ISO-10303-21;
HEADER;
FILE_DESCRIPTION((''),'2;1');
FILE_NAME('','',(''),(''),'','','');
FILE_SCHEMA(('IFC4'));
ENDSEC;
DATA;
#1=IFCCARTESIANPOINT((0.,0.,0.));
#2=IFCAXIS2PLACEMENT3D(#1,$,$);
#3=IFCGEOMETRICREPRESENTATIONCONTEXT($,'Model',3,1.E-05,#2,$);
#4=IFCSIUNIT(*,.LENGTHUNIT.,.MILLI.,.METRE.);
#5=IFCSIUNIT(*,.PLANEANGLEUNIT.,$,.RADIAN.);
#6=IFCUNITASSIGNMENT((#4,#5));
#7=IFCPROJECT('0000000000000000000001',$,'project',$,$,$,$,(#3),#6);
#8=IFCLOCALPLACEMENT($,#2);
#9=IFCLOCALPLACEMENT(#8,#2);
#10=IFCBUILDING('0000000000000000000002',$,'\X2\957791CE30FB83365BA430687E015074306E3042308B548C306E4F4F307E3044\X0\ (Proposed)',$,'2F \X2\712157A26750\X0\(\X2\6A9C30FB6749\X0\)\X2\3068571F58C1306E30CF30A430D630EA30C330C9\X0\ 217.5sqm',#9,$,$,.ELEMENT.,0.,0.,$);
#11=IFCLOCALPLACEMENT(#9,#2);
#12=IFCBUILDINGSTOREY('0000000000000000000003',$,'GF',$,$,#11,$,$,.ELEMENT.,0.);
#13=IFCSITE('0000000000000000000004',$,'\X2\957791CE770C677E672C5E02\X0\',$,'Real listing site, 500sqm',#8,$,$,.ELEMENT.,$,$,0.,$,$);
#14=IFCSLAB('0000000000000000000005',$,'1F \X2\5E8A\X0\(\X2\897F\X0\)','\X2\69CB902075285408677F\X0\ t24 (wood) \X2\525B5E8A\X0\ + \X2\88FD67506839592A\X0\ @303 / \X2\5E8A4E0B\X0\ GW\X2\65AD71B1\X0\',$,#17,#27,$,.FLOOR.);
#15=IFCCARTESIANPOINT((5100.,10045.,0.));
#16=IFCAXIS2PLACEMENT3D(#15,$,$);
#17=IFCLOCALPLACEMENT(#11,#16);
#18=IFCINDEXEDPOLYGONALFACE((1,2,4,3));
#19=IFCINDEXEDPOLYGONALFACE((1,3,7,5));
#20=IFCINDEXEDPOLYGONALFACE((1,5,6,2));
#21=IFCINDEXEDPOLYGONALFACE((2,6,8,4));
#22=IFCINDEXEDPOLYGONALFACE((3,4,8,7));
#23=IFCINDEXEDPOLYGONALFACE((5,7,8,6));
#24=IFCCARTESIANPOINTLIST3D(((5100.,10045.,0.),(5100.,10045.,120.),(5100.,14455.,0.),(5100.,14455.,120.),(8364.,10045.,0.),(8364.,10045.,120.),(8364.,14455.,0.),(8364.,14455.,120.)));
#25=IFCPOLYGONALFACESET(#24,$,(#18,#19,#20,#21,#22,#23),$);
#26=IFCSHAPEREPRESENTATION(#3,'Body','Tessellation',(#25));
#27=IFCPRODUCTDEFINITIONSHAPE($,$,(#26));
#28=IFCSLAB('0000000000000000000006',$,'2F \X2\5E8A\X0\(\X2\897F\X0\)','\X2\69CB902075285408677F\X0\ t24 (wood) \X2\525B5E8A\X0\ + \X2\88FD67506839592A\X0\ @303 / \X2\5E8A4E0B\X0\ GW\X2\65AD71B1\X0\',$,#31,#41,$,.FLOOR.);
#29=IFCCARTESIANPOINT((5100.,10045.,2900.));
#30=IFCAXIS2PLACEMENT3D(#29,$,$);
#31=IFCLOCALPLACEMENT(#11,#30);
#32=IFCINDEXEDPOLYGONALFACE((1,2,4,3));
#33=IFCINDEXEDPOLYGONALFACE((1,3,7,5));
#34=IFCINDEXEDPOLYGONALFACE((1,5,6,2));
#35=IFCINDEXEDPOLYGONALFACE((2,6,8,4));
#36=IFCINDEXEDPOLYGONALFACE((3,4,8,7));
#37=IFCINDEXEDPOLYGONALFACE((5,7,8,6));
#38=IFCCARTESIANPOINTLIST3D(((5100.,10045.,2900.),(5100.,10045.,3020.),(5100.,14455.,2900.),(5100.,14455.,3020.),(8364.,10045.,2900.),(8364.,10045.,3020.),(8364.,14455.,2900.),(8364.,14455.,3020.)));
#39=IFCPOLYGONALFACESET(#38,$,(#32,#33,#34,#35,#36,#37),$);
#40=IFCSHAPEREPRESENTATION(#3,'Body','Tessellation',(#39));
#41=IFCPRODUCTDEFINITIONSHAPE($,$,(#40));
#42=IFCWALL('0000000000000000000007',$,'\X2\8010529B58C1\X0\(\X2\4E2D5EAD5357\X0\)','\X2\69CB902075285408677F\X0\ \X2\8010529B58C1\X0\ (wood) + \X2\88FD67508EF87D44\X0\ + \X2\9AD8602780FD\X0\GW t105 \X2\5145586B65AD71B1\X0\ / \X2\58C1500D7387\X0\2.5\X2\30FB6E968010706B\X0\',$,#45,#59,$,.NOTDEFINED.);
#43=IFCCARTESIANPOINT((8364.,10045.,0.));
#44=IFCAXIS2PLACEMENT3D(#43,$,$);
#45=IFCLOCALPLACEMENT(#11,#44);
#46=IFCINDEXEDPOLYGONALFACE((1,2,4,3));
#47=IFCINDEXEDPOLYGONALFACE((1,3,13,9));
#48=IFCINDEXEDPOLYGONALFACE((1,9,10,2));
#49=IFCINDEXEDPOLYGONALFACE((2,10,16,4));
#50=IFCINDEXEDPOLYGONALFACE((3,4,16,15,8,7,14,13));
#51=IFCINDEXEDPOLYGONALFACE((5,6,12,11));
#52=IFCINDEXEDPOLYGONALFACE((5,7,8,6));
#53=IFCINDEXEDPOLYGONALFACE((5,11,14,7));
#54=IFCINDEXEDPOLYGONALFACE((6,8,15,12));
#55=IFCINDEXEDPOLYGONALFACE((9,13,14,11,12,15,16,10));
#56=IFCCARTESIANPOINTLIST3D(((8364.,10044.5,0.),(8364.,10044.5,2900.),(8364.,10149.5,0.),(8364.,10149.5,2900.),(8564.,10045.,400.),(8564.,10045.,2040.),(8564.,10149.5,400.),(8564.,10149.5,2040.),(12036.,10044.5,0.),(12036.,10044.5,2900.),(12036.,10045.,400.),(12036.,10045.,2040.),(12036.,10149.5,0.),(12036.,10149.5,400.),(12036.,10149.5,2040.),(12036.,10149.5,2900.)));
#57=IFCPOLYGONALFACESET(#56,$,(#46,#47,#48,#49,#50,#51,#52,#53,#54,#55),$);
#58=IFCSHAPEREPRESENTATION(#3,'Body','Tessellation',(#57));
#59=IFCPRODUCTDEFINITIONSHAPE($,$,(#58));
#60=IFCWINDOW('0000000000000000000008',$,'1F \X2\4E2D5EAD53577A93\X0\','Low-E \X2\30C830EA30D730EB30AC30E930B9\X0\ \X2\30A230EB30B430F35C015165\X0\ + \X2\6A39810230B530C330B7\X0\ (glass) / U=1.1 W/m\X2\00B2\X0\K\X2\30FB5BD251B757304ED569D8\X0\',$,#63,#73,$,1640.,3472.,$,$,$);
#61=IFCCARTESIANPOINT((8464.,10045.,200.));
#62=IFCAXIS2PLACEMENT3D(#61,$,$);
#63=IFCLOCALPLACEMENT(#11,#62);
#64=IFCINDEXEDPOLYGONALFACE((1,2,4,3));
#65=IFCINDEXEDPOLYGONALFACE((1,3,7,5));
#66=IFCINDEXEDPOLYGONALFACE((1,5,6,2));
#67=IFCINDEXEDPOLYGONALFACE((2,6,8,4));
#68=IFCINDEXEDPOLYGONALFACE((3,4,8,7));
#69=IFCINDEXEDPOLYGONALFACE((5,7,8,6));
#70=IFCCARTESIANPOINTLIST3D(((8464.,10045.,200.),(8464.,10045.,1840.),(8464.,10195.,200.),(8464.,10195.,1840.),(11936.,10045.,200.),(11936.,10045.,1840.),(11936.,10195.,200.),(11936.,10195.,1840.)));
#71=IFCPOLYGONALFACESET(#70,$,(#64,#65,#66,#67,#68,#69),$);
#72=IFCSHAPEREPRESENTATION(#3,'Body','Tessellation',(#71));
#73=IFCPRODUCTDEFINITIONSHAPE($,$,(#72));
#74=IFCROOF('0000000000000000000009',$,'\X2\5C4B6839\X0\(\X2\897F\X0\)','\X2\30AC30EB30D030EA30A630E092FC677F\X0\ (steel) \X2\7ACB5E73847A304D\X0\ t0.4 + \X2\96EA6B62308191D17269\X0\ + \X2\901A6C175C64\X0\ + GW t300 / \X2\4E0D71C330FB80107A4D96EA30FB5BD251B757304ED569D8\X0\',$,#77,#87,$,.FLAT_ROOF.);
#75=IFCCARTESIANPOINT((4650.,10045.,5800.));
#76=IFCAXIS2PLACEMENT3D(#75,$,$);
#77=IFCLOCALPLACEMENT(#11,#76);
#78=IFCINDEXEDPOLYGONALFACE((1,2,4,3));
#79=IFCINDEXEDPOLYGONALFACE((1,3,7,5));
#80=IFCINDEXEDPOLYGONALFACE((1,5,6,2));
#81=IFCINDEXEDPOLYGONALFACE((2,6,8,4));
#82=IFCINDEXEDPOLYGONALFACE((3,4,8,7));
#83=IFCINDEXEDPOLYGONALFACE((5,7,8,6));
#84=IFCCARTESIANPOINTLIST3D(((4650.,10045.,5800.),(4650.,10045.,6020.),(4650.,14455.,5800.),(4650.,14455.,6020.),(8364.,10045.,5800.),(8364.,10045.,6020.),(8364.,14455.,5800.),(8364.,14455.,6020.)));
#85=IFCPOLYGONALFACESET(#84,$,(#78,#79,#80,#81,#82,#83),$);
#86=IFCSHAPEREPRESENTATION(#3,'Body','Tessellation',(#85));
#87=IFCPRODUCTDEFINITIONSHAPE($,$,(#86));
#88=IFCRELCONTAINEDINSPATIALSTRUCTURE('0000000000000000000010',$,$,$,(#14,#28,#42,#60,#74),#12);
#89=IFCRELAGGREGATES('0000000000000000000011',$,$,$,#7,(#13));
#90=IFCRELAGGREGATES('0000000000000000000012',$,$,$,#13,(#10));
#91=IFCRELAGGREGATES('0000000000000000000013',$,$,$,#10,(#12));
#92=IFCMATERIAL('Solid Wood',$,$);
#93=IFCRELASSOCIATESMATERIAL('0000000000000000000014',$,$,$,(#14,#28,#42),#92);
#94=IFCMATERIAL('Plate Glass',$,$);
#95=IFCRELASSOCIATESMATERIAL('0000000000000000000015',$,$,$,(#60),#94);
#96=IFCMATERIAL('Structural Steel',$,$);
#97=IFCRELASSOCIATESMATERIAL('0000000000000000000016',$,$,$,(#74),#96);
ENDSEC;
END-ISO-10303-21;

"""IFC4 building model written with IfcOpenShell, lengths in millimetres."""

from ifc_helpers import new_model, si_unit, frame, frame_2d, origin, place, context, project, spatial, rectangle, extrude, material, element, fill, save


model = new_model("IFC4")

# Units and contexts
model_context = context("Model", 3, precision=1e-05, world=origin())
ifc_project = project(units=[si_unit("LENGTHUNIT", "METRE", prefix="MILLI"), si_unit("PLANEANGLEUNIT", "RADIAN")], contexts=[model_context])

# Site, building, storey
site_placement = place(None, origin())
site = spatial("IfcSite", under=ifc_project, at=site_placement, Name="長野県松本市", ObjectType="Real listing site, 500sqm", CompositionType="ELEMENT", RefElevation=0.0)
building_placement = place(site_placement, origin())
building = spatial("IfcBuilding", under=site, at=building_placement, Name="長野・茶室と縁側のある和の住まい (Proposed)", ObjectType="2F 無垢材(檜・杉)と土壁のハイブリッド 217.5sqm", CompositionType="ELEMENT", ElevationOfRefHeight=0.0, ElevationOfTerrain=0.0)
storey_placement = place(building_placement, origin())
storey = spatial("IfcBuildingStorey", under=building, at=storey_placement, Name="GF", CompositionType="ELEMENT", Elevation=0.0)

# Shared definitions
ifc_material_1 = material(Name="Solid Wood")

# Slabs
slab_1_placement = place(storey_placement, frame((5100.0, 10045.0, 0.0)))
element("IfcSlab", 1, at=slab_1_placement, inside=storey, material=ifc_material_1, Name="1F 床(西)", Description="構造用合板 t24 (wood) 剛床 + 製材根太 @303 / 床下 GW断熱", PredefinedType="FLOOR", context=model_context, shape_type="SweptSolid", body=[
    extrude(rectangle(XDim=3264.0, YDim=4410.0, at=frame_2d((1632.0, 2205.0))), frame((5100.0, 10045.0, 0.0)), (0.0, 0.0, 1.0), 120.0),
])
slab_2_placement = place(storey_placement, frame((5100.0, 10045.0, 2900.0)))
element("IfcSlab", 2, at=slab_2_placement, inside=storey, material=ifc_material_1, Name="2F 床(西)", Description="構造用合板 t24 (wood) 剛床 + 製材根太 @303 / 床下 GW断熱", PredefinedType="FLOOR", context=model_context, shape_type="SweptSolid", body=[
    extrude(rectangle(XDim=3264.0, YDim=4410.0, at=frame_2d((1632.0, 2205.0))), frame((5100.0, 10045.0, 2900.0)), (0.0, 0.0, 1.0), 120.0),
])

# Wall, opening, window
wall_placement = place(storey_placement, frame((8364.0, 10045.0, 0.0)))
wall = element("IfcWall", 3, at=wall_placement, inside=storey, material=ifc_material_1, Name="耐力壁(中庭南)", Description="構造用合板 耐力壁 (wood) + 製材軸組 + 高性能GW t105 充填断熱 / 壁倍率2.5・準耐火", PredefinedType="NOTDEFINED", context=model_context, shape_type="SweptSolid", body=[
    extrude(rectangle(XDim=3672.0, YDim=105.0, at=frame_2d((1836.0, 52.0))), frame((8364.0, 10045.0, 0.0)), (0.0, 0.0, 1.0), 2900.0),
])
opening_placement = place(storey_placement, frame((8464.0, 10045.0, 200.0)))
opening = element("IfcOpeningElement", 4, at=opening_placement, cuts=wall, PredefinedType="NOTDEFINED", context=model_context, shape_type="SweptSolid", body=[
    extrude(rectangle(XDim=3472.0, YDim=150.0, at=frame_2d((1736.0, 75.0))), frame((8464.0, 10045.0, 200.0)), (0.0, 0.0, 1.0), 1640.0),
])
ifc_material_2 = material(Name="Plate Glass")
window_placement = place(storey_placement, frame((8464.0, 10045.0, 200.0)))
window = element("IfcWindow", 5, at=window_placement, inside=storey, material=ifc_material_2, Name="1F 中庭南窓", Description="Low-E トリプルガラス アルゴン封入 + 樹脂サッシ (glass) / U=1.1 W/m²K・寒冷地仕様", OverallHeight=1640.0, OverallWidth=3472.0, context=model_context, shape_type="SweptSolid", body=[
    extrude(rectangle(XDim=3472.0, YDim=150.0, at=frame_2d((1736.0, 75.0))), frame((8464.0, 10045.0, 200.0)), (0.0, 0.0, 1.0), 1640.0),
])
fill(opening, window)

# Roof
ifc_material_3 = material(Name="Structural Steel")
for number, where, name in (
    (6, (4650.0, 10045.0, 5800.0), "屋根(西)"),
):
    element("IfcRoof", number, at=place(storey_placement, frame(where)), inside=storey, material=ifc_material_3, Name=name, Description="ガルバリウム鋼板 (steel) 立平葺き t0.4 + 雪止め金物 + 通気層 + GW t300 / 不燃・耐積雪・寒冷地仕様", PredefinedType="FLAT_ROOF", context=model_context, shape_type="SweptSolid", body=[
        extrude(rectangle(XDim=3714.0, YDim=4410.0, at=frame_2d((1857.0, 2205.0))), frame((4650.0, 10045.0, 5800.0)), (0.0, 0.0, 1.0), 220.0),
    ])

save(model, "model.ifc")
